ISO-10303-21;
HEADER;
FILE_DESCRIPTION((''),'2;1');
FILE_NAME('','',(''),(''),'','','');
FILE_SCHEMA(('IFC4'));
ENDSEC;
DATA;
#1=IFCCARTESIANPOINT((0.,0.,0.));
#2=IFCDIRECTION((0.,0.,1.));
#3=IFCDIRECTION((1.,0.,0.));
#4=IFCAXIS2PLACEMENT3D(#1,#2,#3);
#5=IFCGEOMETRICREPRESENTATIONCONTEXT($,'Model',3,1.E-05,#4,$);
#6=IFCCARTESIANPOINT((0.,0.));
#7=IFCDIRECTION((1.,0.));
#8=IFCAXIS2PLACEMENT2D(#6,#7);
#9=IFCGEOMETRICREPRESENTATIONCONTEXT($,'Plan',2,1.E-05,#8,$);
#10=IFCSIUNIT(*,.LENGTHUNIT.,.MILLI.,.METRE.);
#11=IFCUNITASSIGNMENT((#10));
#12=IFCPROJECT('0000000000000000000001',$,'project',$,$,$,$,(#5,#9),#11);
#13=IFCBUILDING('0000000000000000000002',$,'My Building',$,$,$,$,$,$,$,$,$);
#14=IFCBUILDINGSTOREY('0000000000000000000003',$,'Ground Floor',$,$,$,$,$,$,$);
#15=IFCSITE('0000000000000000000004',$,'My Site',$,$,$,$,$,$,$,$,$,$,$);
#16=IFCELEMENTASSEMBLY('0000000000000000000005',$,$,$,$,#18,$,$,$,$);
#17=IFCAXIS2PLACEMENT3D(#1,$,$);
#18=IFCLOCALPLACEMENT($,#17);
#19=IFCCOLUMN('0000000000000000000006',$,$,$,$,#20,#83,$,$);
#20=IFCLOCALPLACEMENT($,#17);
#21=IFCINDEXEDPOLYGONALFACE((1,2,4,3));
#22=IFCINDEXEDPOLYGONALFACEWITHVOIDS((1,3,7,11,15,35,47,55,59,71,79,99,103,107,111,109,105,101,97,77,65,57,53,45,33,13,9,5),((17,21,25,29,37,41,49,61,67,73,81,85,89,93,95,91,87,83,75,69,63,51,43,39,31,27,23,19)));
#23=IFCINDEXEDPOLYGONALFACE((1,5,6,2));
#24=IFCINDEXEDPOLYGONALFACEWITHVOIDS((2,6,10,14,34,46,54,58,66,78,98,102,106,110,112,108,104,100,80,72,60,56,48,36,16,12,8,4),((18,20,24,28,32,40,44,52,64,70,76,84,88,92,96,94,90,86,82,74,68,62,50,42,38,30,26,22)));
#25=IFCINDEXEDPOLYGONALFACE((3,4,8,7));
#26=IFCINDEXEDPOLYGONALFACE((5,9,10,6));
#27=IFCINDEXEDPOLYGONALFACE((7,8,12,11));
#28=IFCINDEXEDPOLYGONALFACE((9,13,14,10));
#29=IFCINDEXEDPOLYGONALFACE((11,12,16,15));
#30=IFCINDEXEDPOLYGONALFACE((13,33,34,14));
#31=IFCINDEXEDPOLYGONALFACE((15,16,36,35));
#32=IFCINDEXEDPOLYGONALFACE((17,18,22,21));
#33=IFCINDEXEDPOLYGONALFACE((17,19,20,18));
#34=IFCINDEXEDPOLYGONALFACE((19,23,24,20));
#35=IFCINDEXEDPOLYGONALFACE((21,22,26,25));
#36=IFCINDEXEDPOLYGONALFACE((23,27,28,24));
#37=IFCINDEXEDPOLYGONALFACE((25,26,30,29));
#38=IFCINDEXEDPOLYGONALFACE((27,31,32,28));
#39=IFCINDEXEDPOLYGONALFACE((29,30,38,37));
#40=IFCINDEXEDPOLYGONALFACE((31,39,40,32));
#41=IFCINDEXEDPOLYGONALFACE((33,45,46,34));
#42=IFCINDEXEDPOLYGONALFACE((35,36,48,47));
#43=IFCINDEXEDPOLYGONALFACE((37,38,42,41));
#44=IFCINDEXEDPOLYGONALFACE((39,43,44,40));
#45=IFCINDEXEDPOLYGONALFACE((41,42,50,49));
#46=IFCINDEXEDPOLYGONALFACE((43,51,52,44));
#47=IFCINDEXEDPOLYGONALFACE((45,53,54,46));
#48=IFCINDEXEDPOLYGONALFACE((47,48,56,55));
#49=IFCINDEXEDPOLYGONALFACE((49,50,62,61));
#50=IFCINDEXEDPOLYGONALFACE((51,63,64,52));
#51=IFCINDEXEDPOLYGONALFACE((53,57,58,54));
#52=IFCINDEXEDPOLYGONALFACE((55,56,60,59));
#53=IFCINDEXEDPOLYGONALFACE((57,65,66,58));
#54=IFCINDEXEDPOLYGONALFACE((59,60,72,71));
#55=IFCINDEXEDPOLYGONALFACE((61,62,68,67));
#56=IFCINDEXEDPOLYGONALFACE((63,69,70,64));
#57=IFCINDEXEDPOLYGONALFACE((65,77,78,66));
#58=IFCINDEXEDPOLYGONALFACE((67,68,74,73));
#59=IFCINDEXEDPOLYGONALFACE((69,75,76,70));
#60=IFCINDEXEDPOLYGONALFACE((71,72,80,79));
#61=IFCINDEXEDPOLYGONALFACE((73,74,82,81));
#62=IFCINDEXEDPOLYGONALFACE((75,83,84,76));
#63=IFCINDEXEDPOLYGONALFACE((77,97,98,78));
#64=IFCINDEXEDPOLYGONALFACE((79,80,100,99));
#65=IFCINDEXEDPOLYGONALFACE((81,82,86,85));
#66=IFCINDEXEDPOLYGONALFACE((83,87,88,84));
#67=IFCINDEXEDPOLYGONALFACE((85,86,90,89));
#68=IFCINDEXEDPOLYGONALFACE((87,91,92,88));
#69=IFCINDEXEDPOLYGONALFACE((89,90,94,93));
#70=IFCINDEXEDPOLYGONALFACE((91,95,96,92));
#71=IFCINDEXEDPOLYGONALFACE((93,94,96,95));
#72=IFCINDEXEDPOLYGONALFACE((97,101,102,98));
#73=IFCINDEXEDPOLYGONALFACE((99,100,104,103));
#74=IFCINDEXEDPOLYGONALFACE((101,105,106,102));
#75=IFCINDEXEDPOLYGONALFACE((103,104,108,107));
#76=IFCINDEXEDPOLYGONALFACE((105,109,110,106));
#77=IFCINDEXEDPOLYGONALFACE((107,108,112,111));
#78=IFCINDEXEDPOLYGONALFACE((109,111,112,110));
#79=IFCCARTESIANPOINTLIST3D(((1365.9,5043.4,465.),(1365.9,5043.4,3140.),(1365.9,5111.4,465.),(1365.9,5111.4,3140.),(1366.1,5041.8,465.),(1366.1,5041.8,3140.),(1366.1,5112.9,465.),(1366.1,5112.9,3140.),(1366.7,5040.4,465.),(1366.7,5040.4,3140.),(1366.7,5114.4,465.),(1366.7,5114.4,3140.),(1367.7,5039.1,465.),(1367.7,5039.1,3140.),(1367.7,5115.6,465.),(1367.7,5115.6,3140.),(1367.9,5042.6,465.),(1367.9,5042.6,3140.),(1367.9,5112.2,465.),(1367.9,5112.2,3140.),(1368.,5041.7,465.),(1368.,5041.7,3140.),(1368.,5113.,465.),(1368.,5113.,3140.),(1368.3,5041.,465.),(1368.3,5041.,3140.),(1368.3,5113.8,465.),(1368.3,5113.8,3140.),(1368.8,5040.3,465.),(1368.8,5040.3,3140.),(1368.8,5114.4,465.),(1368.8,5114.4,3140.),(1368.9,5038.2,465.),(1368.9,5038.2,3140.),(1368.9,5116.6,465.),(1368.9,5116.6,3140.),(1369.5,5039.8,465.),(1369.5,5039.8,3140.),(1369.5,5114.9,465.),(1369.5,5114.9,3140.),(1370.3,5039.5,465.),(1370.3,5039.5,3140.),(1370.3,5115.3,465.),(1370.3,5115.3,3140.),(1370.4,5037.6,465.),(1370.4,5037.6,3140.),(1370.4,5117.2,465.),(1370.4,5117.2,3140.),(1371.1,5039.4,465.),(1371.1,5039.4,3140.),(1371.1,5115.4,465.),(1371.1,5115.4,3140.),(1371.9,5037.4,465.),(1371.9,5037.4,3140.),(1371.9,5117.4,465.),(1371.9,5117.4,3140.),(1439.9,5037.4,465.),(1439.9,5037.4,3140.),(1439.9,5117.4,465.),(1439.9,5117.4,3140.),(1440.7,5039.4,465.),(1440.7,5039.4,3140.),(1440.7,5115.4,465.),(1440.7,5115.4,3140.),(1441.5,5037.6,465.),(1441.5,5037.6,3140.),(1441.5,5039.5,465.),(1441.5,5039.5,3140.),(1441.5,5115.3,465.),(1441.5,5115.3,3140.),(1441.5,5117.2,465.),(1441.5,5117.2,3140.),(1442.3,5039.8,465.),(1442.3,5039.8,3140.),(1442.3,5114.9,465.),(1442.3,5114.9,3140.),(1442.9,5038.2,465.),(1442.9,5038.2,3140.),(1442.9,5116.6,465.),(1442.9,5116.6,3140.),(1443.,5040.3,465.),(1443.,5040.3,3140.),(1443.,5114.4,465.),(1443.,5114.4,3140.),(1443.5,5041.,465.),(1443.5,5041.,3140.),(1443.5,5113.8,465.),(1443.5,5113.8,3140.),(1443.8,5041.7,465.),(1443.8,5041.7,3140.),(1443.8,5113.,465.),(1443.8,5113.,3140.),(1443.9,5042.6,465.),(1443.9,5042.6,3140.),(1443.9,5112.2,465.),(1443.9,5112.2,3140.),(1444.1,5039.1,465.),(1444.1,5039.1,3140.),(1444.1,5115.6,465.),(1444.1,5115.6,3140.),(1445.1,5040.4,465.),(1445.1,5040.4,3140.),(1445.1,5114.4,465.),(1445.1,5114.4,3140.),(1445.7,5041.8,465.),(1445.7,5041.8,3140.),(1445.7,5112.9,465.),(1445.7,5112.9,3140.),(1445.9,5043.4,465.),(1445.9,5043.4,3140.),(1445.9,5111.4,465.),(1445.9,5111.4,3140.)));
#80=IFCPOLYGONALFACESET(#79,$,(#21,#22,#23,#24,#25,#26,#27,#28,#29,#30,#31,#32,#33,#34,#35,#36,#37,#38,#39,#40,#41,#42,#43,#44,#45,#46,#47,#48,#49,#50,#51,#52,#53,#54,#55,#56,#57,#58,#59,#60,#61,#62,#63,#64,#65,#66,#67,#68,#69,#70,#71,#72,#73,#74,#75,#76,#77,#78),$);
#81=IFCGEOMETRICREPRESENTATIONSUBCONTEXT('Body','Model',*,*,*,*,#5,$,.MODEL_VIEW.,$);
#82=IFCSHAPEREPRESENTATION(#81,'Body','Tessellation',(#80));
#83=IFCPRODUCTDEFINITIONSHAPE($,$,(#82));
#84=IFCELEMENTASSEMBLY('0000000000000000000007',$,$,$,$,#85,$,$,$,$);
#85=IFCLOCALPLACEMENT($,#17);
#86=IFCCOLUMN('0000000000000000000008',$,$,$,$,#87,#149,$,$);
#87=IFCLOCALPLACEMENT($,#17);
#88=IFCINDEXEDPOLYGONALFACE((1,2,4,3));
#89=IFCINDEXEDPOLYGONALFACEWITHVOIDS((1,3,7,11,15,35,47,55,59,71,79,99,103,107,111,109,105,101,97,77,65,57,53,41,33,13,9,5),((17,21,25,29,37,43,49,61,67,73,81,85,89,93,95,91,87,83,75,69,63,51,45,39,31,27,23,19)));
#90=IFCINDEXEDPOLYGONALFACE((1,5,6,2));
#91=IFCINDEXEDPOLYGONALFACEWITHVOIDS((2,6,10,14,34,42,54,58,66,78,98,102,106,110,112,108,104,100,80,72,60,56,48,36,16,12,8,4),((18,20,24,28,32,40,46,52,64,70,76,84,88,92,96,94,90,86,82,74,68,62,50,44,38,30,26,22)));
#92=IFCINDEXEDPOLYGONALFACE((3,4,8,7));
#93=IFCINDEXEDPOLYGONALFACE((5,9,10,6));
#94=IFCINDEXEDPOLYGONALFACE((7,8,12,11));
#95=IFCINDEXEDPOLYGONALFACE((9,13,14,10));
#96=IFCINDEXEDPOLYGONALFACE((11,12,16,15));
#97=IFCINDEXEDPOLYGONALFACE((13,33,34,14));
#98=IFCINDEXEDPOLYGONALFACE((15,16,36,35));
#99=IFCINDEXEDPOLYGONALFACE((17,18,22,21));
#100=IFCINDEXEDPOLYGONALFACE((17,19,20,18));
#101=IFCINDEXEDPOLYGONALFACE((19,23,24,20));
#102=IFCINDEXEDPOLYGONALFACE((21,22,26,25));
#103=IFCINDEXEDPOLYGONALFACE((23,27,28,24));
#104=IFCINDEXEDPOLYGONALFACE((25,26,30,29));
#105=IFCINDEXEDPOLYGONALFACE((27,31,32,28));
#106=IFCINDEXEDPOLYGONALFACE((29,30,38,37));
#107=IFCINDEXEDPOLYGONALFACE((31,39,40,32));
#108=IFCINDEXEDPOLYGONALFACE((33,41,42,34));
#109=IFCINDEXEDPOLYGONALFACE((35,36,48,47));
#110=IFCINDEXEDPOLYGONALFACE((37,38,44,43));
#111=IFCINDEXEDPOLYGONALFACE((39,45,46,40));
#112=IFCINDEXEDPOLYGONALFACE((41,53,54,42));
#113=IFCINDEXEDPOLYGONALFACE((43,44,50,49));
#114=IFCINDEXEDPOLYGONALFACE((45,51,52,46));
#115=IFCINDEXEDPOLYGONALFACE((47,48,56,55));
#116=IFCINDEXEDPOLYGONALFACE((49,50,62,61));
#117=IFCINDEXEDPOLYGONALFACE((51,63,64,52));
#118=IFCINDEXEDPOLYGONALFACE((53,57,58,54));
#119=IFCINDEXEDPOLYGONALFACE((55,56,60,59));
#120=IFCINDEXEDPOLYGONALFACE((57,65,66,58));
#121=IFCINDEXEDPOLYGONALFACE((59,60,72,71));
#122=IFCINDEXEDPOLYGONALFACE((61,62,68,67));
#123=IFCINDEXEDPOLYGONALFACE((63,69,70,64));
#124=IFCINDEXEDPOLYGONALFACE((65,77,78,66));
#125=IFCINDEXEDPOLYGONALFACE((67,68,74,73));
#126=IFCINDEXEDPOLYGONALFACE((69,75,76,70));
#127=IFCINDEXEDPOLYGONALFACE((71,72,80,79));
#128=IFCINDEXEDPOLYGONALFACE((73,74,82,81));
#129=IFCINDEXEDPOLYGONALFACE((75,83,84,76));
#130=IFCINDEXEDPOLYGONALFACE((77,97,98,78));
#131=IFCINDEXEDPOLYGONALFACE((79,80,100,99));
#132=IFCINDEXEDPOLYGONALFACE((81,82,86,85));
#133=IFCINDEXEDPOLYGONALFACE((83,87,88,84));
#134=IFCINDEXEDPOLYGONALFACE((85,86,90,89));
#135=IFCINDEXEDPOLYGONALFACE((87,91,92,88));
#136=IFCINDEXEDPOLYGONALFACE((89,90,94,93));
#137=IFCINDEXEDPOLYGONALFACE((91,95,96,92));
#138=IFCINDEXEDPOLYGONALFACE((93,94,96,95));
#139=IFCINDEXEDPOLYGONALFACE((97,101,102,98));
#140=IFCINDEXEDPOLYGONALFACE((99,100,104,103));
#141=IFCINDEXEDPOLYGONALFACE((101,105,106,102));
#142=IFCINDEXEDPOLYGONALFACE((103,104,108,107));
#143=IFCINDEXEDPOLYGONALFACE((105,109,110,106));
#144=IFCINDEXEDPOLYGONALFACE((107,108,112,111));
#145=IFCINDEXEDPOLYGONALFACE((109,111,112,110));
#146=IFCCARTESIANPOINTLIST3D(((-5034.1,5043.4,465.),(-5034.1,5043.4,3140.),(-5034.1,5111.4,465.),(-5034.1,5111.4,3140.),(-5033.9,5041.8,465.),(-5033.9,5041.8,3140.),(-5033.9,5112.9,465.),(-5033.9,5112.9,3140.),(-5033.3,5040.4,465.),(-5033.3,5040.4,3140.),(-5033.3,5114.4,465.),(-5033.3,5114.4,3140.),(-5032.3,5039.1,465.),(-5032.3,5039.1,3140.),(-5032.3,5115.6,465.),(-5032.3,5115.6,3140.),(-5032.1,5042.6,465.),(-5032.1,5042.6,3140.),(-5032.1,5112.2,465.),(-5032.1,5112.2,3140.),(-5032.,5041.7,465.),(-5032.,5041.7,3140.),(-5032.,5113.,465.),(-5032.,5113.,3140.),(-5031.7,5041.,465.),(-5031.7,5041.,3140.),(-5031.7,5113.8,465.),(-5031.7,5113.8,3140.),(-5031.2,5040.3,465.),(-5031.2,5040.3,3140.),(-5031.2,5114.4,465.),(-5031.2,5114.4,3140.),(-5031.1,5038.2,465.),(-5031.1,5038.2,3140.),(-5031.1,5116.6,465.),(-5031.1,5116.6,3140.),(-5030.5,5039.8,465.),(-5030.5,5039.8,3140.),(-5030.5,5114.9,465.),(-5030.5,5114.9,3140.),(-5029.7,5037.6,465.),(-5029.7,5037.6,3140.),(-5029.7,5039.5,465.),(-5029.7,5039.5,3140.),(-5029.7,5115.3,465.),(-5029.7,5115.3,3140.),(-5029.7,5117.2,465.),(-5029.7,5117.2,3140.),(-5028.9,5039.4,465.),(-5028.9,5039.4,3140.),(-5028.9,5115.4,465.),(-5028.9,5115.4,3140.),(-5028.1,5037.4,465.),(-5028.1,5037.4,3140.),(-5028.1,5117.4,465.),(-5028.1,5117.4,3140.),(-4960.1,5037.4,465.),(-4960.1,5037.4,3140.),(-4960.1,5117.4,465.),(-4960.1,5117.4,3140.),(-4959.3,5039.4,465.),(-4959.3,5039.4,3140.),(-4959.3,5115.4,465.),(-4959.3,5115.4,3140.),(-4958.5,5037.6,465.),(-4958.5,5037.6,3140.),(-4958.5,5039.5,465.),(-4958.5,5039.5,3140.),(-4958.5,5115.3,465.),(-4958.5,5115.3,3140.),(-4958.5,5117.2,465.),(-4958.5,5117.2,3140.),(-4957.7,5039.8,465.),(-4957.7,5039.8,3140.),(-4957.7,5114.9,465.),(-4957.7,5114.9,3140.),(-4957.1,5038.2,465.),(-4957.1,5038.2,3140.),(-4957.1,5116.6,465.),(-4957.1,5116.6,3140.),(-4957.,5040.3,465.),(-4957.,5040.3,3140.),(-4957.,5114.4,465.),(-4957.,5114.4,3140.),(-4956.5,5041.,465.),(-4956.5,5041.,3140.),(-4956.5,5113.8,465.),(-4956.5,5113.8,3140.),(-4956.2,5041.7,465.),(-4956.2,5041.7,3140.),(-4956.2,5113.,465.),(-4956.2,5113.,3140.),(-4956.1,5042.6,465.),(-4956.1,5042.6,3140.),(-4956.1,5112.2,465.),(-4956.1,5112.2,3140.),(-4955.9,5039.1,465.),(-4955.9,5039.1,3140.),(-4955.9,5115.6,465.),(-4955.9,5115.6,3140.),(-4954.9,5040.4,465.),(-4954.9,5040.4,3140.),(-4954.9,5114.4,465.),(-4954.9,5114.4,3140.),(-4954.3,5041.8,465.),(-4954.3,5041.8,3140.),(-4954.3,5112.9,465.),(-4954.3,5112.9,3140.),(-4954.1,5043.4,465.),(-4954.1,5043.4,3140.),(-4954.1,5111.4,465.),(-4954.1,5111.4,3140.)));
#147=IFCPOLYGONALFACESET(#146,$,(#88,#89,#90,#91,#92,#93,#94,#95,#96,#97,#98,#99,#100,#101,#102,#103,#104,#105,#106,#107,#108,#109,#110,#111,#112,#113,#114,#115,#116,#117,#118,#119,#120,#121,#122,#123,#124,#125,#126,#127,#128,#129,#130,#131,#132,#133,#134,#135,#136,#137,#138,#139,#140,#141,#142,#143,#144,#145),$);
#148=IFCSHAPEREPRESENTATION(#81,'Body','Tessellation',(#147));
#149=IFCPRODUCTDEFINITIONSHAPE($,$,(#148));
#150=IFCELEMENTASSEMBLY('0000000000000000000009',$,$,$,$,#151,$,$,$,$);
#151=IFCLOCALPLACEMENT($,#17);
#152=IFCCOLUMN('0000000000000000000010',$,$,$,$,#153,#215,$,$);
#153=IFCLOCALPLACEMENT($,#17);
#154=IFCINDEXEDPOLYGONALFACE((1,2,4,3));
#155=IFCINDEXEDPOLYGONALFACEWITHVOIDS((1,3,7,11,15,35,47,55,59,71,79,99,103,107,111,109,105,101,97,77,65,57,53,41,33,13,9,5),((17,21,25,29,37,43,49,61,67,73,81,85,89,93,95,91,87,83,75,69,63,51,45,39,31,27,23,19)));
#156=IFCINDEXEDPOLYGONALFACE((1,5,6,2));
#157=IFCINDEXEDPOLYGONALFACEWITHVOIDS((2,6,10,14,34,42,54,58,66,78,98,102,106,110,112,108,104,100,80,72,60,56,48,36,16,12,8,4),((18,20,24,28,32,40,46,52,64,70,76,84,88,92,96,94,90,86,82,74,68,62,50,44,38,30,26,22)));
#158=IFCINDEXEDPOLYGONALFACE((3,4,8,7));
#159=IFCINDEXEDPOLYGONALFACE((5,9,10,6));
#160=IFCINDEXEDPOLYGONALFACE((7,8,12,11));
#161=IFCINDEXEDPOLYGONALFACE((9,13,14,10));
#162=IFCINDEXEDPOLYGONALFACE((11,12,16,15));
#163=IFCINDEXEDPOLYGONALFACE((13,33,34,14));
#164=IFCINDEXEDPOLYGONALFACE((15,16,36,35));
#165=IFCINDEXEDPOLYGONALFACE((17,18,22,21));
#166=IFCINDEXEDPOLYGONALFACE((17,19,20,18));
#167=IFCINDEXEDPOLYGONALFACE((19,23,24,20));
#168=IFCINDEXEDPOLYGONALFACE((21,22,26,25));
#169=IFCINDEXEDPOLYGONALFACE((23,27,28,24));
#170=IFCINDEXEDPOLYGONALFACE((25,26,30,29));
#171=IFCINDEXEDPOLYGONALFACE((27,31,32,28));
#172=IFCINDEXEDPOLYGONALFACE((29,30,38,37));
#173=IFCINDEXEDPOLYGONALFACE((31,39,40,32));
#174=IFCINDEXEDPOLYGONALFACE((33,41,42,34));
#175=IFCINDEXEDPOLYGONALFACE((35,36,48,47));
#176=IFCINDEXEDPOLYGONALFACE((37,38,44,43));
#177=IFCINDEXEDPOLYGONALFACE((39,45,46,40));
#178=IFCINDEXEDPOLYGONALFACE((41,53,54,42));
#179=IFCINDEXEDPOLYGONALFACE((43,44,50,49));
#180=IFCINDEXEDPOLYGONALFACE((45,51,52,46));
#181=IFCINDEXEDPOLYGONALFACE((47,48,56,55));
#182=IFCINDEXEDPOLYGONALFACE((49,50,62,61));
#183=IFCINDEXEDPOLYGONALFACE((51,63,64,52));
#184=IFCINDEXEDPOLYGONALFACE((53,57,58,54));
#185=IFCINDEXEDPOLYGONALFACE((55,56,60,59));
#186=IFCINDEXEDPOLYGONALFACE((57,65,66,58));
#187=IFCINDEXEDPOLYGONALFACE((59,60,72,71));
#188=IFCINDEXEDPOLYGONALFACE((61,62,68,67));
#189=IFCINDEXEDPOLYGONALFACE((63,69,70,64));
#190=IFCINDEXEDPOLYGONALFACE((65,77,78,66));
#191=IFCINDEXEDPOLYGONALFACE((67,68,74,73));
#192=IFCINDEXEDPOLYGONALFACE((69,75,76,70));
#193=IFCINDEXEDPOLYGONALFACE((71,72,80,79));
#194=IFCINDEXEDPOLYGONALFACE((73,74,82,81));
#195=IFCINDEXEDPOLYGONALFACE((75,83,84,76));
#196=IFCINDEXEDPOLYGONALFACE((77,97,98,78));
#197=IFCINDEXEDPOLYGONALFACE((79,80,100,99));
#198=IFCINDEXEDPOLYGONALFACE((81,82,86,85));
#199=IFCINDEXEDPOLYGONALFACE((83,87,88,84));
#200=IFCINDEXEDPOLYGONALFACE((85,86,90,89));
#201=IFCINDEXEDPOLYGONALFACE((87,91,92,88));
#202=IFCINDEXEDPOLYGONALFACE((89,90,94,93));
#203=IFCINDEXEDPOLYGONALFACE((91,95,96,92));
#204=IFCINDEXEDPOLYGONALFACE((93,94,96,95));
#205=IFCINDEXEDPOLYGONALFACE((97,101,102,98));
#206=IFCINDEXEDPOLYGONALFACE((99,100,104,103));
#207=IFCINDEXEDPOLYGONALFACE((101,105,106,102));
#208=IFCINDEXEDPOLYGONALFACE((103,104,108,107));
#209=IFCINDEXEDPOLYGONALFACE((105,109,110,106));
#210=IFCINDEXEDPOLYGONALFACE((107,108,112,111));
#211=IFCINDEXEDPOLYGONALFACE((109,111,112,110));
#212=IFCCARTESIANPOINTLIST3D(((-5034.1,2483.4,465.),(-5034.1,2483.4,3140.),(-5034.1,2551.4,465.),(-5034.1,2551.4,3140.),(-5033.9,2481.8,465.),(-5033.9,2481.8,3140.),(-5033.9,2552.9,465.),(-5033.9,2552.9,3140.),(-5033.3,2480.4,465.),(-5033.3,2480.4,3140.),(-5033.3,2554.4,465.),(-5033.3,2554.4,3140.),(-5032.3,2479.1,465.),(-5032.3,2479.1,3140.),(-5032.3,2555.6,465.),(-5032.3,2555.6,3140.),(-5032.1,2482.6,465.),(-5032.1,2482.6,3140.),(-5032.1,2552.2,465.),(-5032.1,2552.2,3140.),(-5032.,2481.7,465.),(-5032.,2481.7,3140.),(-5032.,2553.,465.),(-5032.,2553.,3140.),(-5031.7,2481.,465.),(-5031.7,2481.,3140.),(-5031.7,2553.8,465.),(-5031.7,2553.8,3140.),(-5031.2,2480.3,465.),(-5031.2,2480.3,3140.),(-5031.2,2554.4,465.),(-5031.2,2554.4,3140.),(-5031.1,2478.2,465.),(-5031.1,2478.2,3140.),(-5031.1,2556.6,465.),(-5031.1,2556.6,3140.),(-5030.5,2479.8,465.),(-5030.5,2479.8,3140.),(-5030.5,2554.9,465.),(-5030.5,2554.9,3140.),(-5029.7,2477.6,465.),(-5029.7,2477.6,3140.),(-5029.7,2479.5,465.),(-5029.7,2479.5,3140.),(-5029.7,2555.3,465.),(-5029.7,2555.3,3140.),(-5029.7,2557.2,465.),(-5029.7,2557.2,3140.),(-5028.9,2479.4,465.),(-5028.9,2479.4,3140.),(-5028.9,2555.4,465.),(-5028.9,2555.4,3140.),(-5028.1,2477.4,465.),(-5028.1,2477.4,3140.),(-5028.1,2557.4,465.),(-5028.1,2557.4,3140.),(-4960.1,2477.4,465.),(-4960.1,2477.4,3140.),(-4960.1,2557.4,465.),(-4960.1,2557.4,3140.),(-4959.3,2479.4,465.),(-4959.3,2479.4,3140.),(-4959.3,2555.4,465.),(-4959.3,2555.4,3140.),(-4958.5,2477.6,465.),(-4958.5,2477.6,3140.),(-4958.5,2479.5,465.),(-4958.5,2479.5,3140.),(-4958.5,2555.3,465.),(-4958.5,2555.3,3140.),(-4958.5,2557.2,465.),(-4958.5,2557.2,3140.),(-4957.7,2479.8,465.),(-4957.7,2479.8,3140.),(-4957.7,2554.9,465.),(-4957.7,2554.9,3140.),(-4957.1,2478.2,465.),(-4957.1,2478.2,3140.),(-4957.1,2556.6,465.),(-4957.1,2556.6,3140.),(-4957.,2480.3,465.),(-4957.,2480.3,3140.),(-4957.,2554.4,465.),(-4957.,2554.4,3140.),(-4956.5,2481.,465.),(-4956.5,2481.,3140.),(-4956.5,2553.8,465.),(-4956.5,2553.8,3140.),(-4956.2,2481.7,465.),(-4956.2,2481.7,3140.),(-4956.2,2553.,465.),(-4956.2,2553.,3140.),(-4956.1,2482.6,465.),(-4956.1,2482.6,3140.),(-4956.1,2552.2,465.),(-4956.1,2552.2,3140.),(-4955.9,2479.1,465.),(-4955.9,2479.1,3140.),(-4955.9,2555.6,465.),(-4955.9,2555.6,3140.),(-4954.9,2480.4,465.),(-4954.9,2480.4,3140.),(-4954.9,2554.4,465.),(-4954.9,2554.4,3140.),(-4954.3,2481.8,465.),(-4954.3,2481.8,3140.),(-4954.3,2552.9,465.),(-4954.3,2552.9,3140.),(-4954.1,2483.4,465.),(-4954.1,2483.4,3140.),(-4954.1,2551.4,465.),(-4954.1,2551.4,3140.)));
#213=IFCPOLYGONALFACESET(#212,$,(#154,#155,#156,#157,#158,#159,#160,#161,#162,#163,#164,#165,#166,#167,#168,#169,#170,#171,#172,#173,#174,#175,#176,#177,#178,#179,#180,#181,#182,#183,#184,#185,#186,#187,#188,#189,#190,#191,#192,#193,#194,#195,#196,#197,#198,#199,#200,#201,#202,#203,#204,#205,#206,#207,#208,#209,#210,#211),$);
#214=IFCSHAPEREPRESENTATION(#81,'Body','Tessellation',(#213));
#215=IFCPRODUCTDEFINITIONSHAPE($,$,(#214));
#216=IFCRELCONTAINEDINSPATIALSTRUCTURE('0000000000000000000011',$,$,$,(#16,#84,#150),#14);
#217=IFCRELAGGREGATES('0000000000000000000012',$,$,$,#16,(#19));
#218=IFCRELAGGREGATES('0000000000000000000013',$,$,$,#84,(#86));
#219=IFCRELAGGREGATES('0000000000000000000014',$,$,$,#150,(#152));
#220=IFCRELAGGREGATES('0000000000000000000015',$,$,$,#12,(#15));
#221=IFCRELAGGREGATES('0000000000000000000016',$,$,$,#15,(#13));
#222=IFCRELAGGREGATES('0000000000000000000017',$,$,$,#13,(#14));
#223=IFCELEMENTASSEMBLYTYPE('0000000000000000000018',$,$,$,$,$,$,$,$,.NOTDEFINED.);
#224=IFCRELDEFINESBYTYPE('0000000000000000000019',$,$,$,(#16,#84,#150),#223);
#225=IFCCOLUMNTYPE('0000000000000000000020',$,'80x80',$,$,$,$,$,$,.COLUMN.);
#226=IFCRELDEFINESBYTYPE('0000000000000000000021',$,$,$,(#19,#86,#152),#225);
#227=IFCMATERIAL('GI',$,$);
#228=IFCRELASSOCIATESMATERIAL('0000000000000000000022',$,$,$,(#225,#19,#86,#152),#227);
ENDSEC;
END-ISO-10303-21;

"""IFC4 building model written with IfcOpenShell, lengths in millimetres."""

from ifc_helpers import new_model, si_unit, frame, origin_with_axes, origin_2d_with_axis, place, context, subcontext, project, spatial, hollow_rectangle, extrude, material, material_profile, profile_set, profile_usage, type_object, element, aggregate, save


model = new_model("IFC4")

# Units and contexts
model_context = context("Model", 3, precision=1e-05, world=origin_with_axes())
plan_context = context("Plan", 2, precision=1e-05, world=origin_2d_with_axis())
body_context = subcontext(model_context, "Body", "Model", "MODEL_VIEW")
ifc_project = project(units=[si_unit("LENGTHUNIT", "METRE", prefix="MILLI")], contexts=[model_context, plan_context])

# Site, building, storey
site = spatial("IfcSite", under=ifc_project, Name="My Site")
building = spatial("IfcBuilding", under=site, Name="My Building")
storey = spatial("IfcBuildingStorey", under=building, Name="Ground Floor")

# Element assemblies, columns
element_assembly_type_1 = type_object("IfcElementAssemblyType", PredefinedType="NOTDEFINED")
ifc_material = material(Name="GI")
ifc_material_profile_1 = material_profile(ifc_material, hollow_rectangle(XDim=80.0, YDim=80.0, WallThickness=2.0, InnerFilletRadius=3.2, OuterFilletRadius=6.0))
ifc_profile_set_1 = profile_set([ifc_material_profile_1], Name="80x80 GI Rectangular Hollow")
column_type = type_object("IfcColumnType", Name="80x80", PredefinedType="COLUMN", material=ifc_profile_set_1)
assembly_1_placement = place(None, frame((1405.9, 5077.4, 465.0), z_axis=(0.0, 0.0, 1.0), x_axis=(1.0, 0.0, 0.0)))
assembly_1 = element("IfcElementAssembly", 1, at=assembly_1_placement, inside=storey, type_object=element_assembly_type_1)
ifc_profile_usage_1 = profile_usage(ifc_profile_set_1)
column_1_placement = place(assembly_1_placement, origin_with_axes())
column_1 = element("IfcColumn", 2, at=column_1_placement, type_object=column_type, material=ifc_profile_usage_1, context=body_context, shape_type="SweptSolid", body=[
    extrude(hollow_rectangle(XDim=80.0, YDim=80.0, WallThickness=2.0, InnerFilletRadius=3.2, OuterFilletRadius=6.0), origin_with_axes(), (0.0, 0.0, 1.0), 2675.0),
])
aggregate(assembly_1, [column_1])
assembly_2_placement = place(None, frame((-4994.1, 5077.4, 465.0), z_axis=(0.0, 0.0, 1.0), x_axis=(1.0, 0.0, 0.0)))
assembly_2 = element("IfcElementAssembly", 3, at=assembly_2_placement, inside=storey, type_object=element_assembly_type_1)
ifc_profile_usage_2 = profile_usage(ifc_profile_set_1)
column_2_placement = place(assembly_2_placement, origin_with_axes())
column_2 = element("IfcColumn", 4, at=column_2_placement, type_object=column_type, material=ifc_profile_usage_2, context=body_context, shape_type="SweptSolid", body=[
    extrude(hollow_rectangle(XDim=80.0, YDim=80.0, WallThickness=2.0, InnerFilletRadius=3.2, OuterFilletRadius=6.0), origin_with_axes(), (0.0, 0.0, 1.0), 2675.0),
])
aggregate(assembly_2, [column_2])
assembly_3_placement = place(None, frame((-4994.1, 2517.4, 465.0), z_axis=(0.0, 0.0, 1.0), x_axis=(1.0, 0.0, 0.0)))
assembly_3 = element("IfcElementAssembly", 5, at=assembly_3_placement, inside=storey, type_object=element_assembly_type_1)
ifc_profile_usage_3 = profile_usage(ifc_profile_set_1)
column_3_placement = place(assembly_3_placement, origin_with_axes())
column_3 = element("IfcColumn", 6, at=column_3_placement, type_object=column_type, material=ifc_profile_usage_3, context=body_context, shape_type="SweptSolid", body=[
    extrude(hollow_rectangle(XDim=80.0, YDim=80.0, WallThickness=2.0, InnerFilletRadius=3.2, OuterFilletRadius=6.0), origin_with_axes(), (0.0, 0.0, 1.0), 2675.0),
])
aggregate(assembly_3, [column_3])

save(model, "model.ifc")
